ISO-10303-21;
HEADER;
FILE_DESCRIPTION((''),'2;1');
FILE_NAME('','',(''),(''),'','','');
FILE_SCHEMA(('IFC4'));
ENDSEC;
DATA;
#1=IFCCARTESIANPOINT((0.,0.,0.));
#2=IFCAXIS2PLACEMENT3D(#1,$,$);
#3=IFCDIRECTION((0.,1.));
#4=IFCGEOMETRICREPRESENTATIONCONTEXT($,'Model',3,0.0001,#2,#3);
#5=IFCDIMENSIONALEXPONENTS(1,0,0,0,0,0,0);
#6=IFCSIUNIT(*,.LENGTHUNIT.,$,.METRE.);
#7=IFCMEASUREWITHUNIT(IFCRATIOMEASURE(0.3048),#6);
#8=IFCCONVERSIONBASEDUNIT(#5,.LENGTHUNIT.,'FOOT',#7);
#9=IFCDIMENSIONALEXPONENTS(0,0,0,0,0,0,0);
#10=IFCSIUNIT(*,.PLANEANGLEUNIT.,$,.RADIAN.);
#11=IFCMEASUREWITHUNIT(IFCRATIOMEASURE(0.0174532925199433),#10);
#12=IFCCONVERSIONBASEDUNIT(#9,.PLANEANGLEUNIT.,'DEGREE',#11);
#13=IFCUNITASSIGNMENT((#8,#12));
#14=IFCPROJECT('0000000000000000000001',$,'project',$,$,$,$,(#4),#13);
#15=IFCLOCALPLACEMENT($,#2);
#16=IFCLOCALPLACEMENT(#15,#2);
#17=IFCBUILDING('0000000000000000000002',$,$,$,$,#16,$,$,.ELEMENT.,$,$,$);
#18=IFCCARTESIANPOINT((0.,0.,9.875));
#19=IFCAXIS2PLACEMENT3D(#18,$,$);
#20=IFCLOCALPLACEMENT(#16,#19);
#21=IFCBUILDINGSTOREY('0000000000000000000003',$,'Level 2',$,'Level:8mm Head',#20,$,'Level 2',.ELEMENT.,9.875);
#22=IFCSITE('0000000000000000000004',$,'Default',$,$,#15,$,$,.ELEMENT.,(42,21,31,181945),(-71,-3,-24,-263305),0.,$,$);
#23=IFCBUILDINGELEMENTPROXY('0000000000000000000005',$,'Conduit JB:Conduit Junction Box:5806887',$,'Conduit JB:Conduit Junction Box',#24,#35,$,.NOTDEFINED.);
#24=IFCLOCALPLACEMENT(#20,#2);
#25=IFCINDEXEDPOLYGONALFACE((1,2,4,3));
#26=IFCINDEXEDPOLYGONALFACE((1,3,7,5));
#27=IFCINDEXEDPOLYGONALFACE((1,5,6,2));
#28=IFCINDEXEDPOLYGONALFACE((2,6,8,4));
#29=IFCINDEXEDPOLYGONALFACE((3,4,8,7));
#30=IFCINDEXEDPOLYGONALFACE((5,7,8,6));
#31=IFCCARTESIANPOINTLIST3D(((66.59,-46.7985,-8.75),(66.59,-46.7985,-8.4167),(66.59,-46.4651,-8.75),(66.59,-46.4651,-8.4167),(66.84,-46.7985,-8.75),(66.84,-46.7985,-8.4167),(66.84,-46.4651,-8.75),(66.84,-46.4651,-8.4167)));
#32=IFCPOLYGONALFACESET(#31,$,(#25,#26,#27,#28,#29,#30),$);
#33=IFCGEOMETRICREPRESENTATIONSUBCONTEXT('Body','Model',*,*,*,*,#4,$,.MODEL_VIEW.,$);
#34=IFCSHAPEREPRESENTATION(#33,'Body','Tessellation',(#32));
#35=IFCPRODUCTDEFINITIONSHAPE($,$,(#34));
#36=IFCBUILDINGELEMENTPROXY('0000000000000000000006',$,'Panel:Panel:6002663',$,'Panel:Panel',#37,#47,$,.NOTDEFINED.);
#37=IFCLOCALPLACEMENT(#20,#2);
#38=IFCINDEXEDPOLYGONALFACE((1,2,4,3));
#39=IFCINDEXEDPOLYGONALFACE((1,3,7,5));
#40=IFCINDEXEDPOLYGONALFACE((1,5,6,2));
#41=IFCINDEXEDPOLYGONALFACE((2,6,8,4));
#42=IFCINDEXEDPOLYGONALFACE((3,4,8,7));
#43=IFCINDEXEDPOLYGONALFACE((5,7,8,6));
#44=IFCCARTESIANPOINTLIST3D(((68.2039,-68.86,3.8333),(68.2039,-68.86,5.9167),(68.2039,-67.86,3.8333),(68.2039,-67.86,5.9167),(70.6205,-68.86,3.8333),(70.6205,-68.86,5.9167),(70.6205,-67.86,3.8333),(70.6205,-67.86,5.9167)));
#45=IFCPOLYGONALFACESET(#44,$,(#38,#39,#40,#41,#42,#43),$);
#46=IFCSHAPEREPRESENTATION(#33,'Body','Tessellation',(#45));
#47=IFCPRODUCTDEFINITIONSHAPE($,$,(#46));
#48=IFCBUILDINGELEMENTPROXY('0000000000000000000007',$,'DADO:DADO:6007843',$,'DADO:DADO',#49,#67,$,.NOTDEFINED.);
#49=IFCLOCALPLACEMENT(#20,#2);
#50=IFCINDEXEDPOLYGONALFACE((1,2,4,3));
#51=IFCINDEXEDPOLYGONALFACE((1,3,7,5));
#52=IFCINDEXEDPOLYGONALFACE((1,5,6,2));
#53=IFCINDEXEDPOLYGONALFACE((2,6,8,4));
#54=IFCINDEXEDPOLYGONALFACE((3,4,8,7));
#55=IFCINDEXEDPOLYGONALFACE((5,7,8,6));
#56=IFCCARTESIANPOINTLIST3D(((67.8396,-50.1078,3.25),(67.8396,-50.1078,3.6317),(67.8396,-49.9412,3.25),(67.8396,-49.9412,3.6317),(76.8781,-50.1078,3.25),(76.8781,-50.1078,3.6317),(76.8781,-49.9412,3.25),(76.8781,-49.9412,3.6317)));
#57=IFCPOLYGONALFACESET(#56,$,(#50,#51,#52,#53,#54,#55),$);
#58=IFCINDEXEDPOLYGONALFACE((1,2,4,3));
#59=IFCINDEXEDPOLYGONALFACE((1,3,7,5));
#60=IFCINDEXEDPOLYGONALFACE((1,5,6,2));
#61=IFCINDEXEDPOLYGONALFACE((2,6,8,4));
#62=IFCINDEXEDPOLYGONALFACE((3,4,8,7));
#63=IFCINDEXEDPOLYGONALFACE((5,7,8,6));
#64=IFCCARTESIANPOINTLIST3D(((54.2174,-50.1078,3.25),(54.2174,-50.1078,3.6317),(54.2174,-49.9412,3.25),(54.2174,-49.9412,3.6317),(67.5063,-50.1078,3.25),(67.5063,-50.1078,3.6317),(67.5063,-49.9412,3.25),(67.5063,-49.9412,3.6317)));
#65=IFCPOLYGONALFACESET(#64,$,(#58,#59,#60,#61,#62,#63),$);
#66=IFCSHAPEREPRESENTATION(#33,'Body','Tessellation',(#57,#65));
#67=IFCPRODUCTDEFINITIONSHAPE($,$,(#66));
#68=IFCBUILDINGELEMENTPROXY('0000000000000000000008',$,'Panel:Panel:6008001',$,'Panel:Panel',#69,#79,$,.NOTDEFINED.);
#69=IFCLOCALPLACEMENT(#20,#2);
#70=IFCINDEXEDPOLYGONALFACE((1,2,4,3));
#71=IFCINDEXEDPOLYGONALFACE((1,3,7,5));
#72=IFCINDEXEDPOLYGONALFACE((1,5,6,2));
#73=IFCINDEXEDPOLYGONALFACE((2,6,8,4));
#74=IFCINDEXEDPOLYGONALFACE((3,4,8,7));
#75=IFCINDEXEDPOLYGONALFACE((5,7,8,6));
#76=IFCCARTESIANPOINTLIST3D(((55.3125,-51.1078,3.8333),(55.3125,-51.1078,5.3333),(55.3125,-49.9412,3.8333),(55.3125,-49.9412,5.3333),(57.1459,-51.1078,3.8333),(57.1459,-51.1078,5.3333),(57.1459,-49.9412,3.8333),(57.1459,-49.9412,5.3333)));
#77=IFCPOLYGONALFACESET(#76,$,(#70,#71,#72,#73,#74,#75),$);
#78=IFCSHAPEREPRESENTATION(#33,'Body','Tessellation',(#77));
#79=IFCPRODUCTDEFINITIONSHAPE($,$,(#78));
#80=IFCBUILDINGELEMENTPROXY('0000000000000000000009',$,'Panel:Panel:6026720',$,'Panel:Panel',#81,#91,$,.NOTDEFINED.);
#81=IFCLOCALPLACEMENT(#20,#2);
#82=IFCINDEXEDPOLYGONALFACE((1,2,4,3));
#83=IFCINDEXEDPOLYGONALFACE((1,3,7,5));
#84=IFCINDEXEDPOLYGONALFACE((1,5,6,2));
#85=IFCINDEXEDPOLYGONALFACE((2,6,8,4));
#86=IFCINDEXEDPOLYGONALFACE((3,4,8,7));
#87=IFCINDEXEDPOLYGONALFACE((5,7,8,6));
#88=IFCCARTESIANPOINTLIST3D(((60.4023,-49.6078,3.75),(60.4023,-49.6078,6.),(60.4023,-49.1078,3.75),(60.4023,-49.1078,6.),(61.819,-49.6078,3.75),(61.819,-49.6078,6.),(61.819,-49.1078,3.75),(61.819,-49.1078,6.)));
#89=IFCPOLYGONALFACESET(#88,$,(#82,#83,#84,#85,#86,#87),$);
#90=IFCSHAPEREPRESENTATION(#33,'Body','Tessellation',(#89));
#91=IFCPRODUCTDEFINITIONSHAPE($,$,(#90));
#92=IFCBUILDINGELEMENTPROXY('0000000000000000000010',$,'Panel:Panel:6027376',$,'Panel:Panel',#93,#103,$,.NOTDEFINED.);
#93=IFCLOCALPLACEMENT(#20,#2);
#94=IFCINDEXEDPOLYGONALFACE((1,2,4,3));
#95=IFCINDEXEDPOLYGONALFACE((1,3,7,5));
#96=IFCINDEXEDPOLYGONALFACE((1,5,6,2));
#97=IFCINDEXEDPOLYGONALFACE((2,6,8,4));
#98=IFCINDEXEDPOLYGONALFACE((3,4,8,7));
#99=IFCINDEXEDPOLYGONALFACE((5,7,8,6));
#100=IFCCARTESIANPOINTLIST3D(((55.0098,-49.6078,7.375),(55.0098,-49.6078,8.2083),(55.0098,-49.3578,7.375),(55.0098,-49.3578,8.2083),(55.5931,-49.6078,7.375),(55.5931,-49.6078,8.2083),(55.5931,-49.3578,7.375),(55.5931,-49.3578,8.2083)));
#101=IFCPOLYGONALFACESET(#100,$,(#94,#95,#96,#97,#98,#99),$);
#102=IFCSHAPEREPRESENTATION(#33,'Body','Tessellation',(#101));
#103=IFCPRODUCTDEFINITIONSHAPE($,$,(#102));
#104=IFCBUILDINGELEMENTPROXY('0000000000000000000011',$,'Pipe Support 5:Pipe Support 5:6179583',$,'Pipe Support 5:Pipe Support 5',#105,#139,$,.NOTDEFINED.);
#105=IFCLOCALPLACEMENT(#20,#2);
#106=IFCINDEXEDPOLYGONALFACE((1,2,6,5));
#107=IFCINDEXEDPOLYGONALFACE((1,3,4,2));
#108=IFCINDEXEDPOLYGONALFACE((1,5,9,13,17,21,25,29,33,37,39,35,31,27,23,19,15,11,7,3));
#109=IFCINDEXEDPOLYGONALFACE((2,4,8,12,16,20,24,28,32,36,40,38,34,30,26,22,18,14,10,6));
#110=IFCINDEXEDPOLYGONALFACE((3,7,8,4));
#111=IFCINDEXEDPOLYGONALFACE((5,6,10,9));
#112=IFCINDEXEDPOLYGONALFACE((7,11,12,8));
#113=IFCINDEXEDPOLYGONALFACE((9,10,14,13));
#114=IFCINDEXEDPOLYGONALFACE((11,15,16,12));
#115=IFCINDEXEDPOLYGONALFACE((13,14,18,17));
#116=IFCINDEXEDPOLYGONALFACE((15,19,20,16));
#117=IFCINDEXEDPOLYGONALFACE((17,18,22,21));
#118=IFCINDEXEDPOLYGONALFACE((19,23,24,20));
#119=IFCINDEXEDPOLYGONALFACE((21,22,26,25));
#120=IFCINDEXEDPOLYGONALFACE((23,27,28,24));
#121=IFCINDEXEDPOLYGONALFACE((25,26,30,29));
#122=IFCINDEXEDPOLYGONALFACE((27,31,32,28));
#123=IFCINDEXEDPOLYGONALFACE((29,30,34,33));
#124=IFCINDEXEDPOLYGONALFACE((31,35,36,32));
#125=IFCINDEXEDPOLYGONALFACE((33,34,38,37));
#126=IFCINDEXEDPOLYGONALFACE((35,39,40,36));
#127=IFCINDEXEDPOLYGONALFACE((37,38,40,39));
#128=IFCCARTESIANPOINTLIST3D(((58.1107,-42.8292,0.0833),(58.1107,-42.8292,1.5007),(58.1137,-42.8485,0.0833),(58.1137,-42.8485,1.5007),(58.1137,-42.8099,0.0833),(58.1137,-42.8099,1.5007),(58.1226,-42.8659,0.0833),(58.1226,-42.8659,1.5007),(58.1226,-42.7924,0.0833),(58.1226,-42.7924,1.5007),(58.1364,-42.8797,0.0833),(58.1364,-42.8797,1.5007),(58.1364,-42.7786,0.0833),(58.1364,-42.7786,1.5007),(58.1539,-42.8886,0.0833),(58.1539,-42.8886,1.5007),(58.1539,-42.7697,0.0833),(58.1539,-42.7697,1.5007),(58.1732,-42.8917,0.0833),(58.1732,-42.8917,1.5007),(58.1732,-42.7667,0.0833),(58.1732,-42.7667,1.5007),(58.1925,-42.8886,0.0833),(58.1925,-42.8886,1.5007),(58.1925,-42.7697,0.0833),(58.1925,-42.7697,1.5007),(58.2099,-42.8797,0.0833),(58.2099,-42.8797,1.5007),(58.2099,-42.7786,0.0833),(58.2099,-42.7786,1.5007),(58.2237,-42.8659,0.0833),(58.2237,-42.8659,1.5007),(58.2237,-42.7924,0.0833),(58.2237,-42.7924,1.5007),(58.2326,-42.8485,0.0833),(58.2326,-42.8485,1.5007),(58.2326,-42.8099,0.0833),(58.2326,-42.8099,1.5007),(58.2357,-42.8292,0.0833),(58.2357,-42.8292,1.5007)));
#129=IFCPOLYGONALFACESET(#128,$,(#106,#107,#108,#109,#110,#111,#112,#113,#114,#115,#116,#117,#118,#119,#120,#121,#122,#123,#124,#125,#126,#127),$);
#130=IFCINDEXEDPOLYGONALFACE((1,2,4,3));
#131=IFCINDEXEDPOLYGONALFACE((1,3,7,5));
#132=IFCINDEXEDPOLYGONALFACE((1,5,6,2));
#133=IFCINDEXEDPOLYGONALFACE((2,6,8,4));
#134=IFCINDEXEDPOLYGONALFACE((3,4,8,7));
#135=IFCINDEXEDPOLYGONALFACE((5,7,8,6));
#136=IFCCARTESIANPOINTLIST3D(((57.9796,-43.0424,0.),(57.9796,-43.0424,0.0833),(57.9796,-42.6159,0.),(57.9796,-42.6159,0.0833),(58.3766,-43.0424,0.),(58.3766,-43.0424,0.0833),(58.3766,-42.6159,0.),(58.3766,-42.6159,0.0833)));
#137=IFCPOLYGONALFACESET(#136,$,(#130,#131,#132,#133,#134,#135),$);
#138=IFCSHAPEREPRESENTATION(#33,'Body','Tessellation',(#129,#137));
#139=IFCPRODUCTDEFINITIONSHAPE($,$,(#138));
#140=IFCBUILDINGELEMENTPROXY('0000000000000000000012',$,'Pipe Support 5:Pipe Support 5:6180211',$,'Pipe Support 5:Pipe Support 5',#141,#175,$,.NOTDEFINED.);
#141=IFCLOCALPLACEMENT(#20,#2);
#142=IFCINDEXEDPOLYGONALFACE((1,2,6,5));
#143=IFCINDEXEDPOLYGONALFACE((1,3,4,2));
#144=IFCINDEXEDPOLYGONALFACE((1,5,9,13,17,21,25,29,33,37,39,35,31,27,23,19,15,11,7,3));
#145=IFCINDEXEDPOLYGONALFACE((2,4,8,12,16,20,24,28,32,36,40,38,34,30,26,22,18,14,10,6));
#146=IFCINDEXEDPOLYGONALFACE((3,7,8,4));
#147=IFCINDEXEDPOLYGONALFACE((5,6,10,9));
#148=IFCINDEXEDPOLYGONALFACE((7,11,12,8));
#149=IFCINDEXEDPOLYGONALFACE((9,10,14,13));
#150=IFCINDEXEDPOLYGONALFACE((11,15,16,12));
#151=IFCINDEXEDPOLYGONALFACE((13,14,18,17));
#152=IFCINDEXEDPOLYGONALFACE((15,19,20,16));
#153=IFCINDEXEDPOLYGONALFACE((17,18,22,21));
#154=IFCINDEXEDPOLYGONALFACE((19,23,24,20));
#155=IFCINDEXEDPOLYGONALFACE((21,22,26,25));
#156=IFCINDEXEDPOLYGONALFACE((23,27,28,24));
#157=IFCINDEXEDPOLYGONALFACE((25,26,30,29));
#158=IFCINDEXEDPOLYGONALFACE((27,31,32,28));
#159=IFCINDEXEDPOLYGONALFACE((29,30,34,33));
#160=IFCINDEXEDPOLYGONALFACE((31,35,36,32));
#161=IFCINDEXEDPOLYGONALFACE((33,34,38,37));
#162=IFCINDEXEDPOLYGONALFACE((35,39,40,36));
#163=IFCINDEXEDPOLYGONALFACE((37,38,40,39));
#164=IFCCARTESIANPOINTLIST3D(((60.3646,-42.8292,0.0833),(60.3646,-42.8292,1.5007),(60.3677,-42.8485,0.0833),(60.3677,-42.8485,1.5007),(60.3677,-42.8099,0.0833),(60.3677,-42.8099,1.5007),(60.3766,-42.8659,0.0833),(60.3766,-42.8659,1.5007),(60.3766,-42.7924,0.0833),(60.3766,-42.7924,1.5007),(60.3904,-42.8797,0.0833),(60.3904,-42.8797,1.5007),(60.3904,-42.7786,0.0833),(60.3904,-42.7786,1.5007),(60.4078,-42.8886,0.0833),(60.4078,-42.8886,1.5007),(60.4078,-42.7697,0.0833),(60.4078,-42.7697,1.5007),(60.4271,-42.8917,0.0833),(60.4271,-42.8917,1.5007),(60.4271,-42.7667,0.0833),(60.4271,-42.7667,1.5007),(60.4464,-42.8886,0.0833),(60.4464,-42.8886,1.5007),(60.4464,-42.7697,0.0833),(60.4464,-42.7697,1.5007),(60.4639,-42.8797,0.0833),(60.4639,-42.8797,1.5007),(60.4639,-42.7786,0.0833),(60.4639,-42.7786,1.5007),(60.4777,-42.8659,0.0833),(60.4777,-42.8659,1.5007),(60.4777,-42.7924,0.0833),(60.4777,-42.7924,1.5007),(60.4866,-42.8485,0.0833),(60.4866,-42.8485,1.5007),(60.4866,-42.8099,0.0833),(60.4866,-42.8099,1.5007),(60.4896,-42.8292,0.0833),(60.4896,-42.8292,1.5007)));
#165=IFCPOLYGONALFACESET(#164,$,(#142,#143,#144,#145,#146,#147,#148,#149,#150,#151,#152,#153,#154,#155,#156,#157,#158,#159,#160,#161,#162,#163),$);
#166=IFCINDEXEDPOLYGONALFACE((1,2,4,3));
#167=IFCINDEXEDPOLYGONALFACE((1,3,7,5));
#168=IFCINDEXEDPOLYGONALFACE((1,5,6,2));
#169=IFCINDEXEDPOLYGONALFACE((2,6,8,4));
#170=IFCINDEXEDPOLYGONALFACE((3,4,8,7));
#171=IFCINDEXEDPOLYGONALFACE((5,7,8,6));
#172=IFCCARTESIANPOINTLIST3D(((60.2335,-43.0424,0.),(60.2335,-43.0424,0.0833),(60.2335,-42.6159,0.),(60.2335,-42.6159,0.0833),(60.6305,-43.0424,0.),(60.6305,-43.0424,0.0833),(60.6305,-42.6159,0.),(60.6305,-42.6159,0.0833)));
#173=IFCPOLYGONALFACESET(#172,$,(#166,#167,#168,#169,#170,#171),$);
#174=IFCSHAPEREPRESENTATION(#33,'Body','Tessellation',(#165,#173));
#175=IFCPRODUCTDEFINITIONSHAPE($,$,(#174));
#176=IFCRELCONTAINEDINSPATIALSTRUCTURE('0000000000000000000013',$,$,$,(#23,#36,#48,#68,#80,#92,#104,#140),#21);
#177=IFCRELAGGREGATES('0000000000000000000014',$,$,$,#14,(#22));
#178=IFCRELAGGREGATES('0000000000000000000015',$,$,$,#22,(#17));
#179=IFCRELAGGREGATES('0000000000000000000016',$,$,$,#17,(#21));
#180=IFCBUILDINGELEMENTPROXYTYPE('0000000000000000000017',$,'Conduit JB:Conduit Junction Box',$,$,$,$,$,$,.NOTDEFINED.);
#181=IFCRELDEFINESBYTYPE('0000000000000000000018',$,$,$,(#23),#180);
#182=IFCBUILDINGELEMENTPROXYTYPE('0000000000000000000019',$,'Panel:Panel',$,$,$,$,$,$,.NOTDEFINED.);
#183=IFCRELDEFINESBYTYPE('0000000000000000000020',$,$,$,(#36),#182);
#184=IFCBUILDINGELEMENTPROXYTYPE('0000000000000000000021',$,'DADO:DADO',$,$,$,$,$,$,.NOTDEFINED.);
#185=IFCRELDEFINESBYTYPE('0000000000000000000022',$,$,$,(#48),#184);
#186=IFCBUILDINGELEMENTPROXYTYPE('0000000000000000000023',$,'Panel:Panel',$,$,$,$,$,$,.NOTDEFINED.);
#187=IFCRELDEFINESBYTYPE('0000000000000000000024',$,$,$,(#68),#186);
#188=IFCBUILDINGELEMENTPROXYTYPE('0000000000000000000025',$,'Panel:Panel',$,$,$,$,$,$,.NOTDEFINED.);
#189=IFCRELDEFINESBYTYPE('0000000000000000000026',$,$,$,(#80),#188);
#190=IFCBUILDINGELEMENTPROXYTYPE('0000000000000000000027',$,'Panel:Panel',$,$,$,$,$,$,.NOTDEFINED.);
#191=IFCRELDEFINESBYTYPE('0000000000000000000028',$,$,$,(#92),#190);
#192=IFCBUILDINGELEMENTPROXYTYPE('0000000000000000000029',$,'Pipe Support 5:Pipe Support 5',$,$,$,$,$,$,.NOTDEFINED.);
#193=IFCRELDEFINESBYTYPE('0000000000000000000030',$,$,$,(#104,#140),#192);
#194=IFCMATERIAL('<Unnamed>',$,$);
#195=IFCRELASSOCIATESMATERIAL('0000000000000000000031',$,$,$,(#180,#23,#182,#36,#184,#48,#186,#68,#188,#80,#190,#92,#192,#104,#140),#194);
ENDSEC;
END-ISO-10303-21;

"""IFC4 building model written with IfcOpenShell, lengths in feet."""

from ifc_helpers import new_model, entity, si_unit, converted_unit, direction, frame, origin, place, context, subcontext, project, spatial, indexed_curve, outline, extrude, source, transform, mapped, material, type_object, type_shapes, element, save


model = new_model("IFC4")

# Units and contexts
model_context = context("Model", 3, precision=0.0001, world=origin(), true_north=direction((0.0, 1.0)))
body_context = subcontext(model_context, "Body", "Model", "MODEL_VIEW")
ifc_project = project(units=[converted_unit("LENGTHUNIT", "FOOT", entity("IfcRatioMeasure", 0.3048), si_unit("LENGTHUNIT", "METRE"), dimensions=[1, 0, 0, 0, 0, 0, 0]), converted_unit("PLANEANGLEUNIT", "DEGREE", entity("IfcRatioMeasure", 0.0174532925199433), si_unit("PLANEANGLEUNIT", "RADIAN"), dimensions=[0, 0, 0, 0, 0, 0, 0])], contexts=[model_context])

# Site, building, storey
site_placement = place(None, origin())
site = spatial("IfcSite", under=ifc_project, at=site_placement, Name="Default", CompositionType="ELEMENT", RefLatitude=(42, 21, 31, 181945), RefLongitude=(-71, -3, -24, -263305), RefElevation=0.0)
building_placement = place(site_placement, origin())
building = spatial("IfcBuilding", under=site, at=building_placement, CompositionType="ELEMENT")
storey_placement = place(building_placement, frame((0.0, 0.0, 9.875)))
storey = spatial("IfcBuildingStorey", under=building, at=storey_placement, Name="Level 2", ObjectType="Level:8mm Head", LongName="Level 2", CompositionType="ELEMENT", Elevation=9.875)

# Shared definitions
ifc_material_1 = material(Name="<Unnamed>")

# Building element proxies
building_element_proxy_type_1 = type_object("IfcBuildingElementProxyType", Name="Conduit JB:Conduit Junction Box", PredefinedType="NOTDEFINED", material=ifc_material_1)
shared_shape_1 = source(origin(), body_context, "Body", "SweptSolid", [
    extrude(outline(indexed_curve([(-0.125, -0.1667), (0.125, -0.1667), (0.125, 0.1667), (-0.125, 0.1667), (-0.125, -0.1667)], self_intersect=False)), frame((0.0, -0.125, 0.0), z_axis=(0.0, 0.0, 1.0), x_axis=(0.0, 1.0, 0.0)), (0.0, 0.0, 1.0), 0.3333),
])
type_shapes(building_element_proxy_type_1, [shared_shape_1])
proxy_1_placement = place(storey_placement, frame((66.59, -46.6318, -8.75), z_axis=(0.0, 0.0, 1.0), x_axis=(0.0, 1.0, 0.0)))
element("IfcBuildingElementProxy", 1, at=proxy_1_placement, inside=storey, type_object=building_element_proxy_type_1, material=ifc_material_1, Name="Conduit JB:Conduit Junction Box:5806887", ObjectType="Conduit JB:Conduit Junction Box", PredefinedType="NOTDEFINED", context=body_context, shape_type="MappedRepresentation", body=[
    mapped(shared_shape_1, transform((0.0, 0.0, 0.0), scale=1.0)),
])
building_element_proxy_type_2 = type_object("IfcBuildingElementProxyType", Name="Panel:Panel", PredefinedType="NOTDEFINED", material=ifc_material_1)
shared_shape_2 = source(origin(), body_context, "Body", "SweptSolid", [
    extrude(outline(indexed_curve([(-0.5, -1.2083), (0.5, -1.2083), (0.5, 1.2083), (-0.5, 1.2083), (-0.5, -1.2083)], self_intersect=False)), frame((0.0, -0.5, 0.0), z_axis=(0.0, 0.0, 1.0), x_axis=(0.0, 1.0, 0.0)), (0.0, 0.0, 1.0), 2.0833),
])
type_shapes(building_element_proxy_type_2, [shared_shape_2])
proxy_2_placement = place(storey_placement, frame((69.4122, -68.86, 3.8333), z_axis=(0.0, 0.0, 1.0), x_axis=(-1.0, 0.0, 0.0)))
element("IfcBuildingElementProxy", 2, at=proxy_2_placement, inside=storey, type_object=building_element_proxy_type_2, material=ifc_material_1, Name="Panel:Panel:6002663", ObjectType="Panel:Panel", PredefinedType="NOTDEFINED", context=body_context, shape_type="MappedRepresentation", body=[
    mapped(shared_shape_2, transform((0.0, 0.0, 0.0), scale=1.0)),
])
building_element_proxy_type_3 = type_object("IfcBuildingElementProxyType", Name="DADO:DADO", PredefinedType="NOTDEFINED", material=ifc_material_1)
shared_shape_3 = source(origin(), body_context, "Body", "SweptSolid", [
    extrude(outline(indexed_curve([(-0.0833, -4.5192), (0.0833, -4.5192), (0.0833, 4.5192), (-0.0833, 4.5192), (-0.0833, -4.5192)], self_intersect=False)), frame((6.8111, 0.0, 0.0), z_axis=(0.0, 0.0, 1.0), x_axis=(0.0, 1.0, 0.0)), (0.0, 0.0, 1.0), 0.3817),
    extrude(outline(indexed_curve([(-0.0833, -6.6445), (0.0833, -6.6445), (0.0833, 6.6445), (-0.0833, 6.6445), (-0.0833, -6.6445)], self_intersect=False)), frame((-4.6859, 0.0, 0.0), z_axis=(0.0, 0.0, 1.0), x_axis=(0.0, 1.0, 0.0)), (0.0, 0.0, 1.0), 0.3817),
])
type_shapes(building_element_proxy_type_3, [shared_shape_3])
proxy_3_placement = place(storey_placement, frame((65.5477, -50.0245, 3.25)))
element("IfcBuildingElementProxy", 3, at=proxy_3_placement, inside=storey, type_object=building_element_proxy_type_3, material=ifc_material_1, Name="DADO:DADO:6007843", ObjectType="DADO:DADO", PredefinedType="NOTDEFINED", context=body_context, shape_type="MappedRepresentation", body=[
    mapped(shared_shape_3, transform((0.0, 0.0, 0.0), scale=1.0)),
])
building_element_proxy_type_4 = type_object("IfcBuildingElementProxyType", Name="Panel:Panel", PredefinedType="NOTDEFINED", material=ifc_material_1)
shared_shape_4 = source(origin(), body_context, "Body", "SweptSolid", [
    extrude(outline(indexed_curve([(-0.5833, -0.9167), (0.5833, -0.9167), (0.5833, 0.9167), (-0.5833, 0.9167), (-0.5833, -0.9167)], self_intersect=False)), frame((0.0, -0.5833, 0.0), z_axis=(0.0, 0.0, 1.0), x_axis=(0.0, 1.0, 0.0)), (0.0, 0.0, 1.0), 1.5),
])
type_shapes(building_element_proxy_type_4, [shared_shape_4])
proxy_4_placement = place(storey_placement, frame((56.2292, -49.9412, 3.8333)))
element("IfcBuildingElementProxy", 4, at=proxy_4_placement, inside=storey, type_object=building_element_proxy_type_4, material=ifc_material_1, Name="Panel:Panel:6008001", ObjectType="Panel:Panel", PredefinedType="NOTDEFINED", context=body_context, shape_type="MappedRepresentation", body=[
    mapped(shared_shape_4, transform((0.0, 0.0, 0.0), scale=1.0)),
])
building_element_proxy_type_5 = type_object("IfcBuildingElementProxyType", Name="Panel:Panel", PredefinedType="NOTDEFINED", material=ifc_material_1)
shared_shape_5 = source(origin(), body_context, "Body", "SweptSolid", [
    extrude(outline(indexed_curve([(-0.25, -0.7083), (0.25, -0.7083), (0.25, 0.7083), (-0.25, 0.7083), (-0.25, -0.7083)], self_intersect=False)), frame((0.0, -0.25, 0.0), z_axis=(0.0, 0.0, 1.0), x_axis=(0.0, 1.0, 0.0)), (0.0, 0.0, 1.0), 2.25),
])
type_shapes(building_element_proxy_type_5, [shared_shape_5])
proxy_5_placement = place(storey_placement, frame((61.1106, -49.6078, 3.75), z_axis=(0.0, 0.0, 1.0), x_axis=(-1.0, 0.0, 0.0)))
element("IfcBuildingElementProxy", 5, at=proxy_5_placement, inside=storey, type_object=building_element_proxy_type_5, material=ifc_material_1, Name="Panel:Panel:6026720", ObjectType="Panel:Panel", PredefinedType="NOTDEFINED", context=body_context, shape_type="MappedRepresentation", body=[
    mapped(shared_shape_5, transform((0.0, 0.0, 0.0), scale=1.0)),
])
building_element_proxy_type_6 = type_object("IfcBuildingElementProxyType", Name="Panel:Panel", PredefinedType="NOTDEFINED", material=ifc_material_1)
shared_shape_6 = source(origin(), body_context, "Body", "SweptSolid", [
    extrude(outline(indexed_curve([(-0.125, -0.2917), (0.125, -0.2917), (0.125, 0.2917), (-0.125, 0.2917), (-0.125, -0.2917)], self_intersect=False)), frame((0.0, -0.125, 0.0), z_axis=(0.0, 0.0, 1.0), x_axis=(0.0, 1.0, 0.0)), (0.0, 0.0, 1.0), 0.8333),
])
type_shapes(building_element_proxy_type_6, [shared_shape_6])
proxy_6_placement = place(storey_placement, frame((55.3015, -49.6078, 7.375), z_axis=(0.0, 0.0, 1.0), x_axis=(-1.0, 0.0, 0.0)))
element("IfcBuildingElementProxy", 6, at=proxy_6_placement, inside=storey, type_object=building_element_proxy_type_6, material=ifc_material_1, Name="Panel:Panel:6027376", ObjectType="Panel:Panel", PredefinedType="NOTDEFINED", context=body_context, shape_type="MappedRepresentation", body=[
    mapped(shared_shape_6, transform((0.0, 0.0, 0.0), scale=1.0)),
])
building_element_proxy_type_7 = type_object("IfcBuildingElementProxyType", Name="Pipe Support 5:Pipe Support 5", PredefinedType="NOTDEFINED", material=ifc_material_1)
shared_shape_7 = source(origin(), body_context, "Body", "SweptSolid", [
    extrude(outline(indexed_curve([(0.0625, 0.0), (0.0594, 0.0193), (0.0506, 0.0367), (0.0367, 0.0506), (0.0193, 0.0594), (0.0, 0.0625), (-0.0193, 0.0594), (-0.0367, 0.0506), (-0.0506, 0.0367), (-0.0594, 0.0193), (-0.0625, 0.0), (-0.0594, -0.0193), (-0.0506, -0.0367), (-0.0367, -0.0506), (-0.0193, -0.0594), (0.0, -0.0625), (0.0193, -0.0594), (0.0367, -0.0506), (0.0506, -0.0367), (0.0594, -0.0193), (0.0625, 0.0)], self_intersect=False)), frame((-0.0049, 0.0, 0.0833)), (0.0, 0.0, 1.0), 1.4174),
    extrude(outline(indexed_curve([(-0.1985, -0.2133), (0.1985, -0.2133), (0.1985, 0.2133), (-0.1985, 0.2133), (-0.1985, -0.2133)], self_intersect=False)), frame((0.0, 0.0, 0.0), z_axis=(0.0, 0.0, 1.0), x_axis=(-1.0, 0.0, 0.0)), (0.0, 0.0, 1.0), 0.0833),
])
type_shapes(building_element_proxy_type_7, [shared_shape_7])
for number, where, name in (
    (7, (58.1781, -42.8292, 0.0), "Pipe Support 5:Pipe Support 5:6179583"),
    (8, (60.432, -42.8292, 0.0), "Pipe Support 5:Pipe Support 5:6180211"),
):
    element("IfcBuildingElementProxy", number, at=place(storey_placement, frame(where)), inside=storey, type_object=building_element_proxy_type_7, material=ifc_material_1, Name=name, ObjectType="Pipe Support 5:Pipe Support 5", PredefinedType="NOTDEFINED", context=body_context, shape_type="MappedRepresentation", body=[
        mapped(shared_shape_7, transform((0.0, 0.0, 0.0), scale=1.0)),
    ])

save(model, "model.ifc")
